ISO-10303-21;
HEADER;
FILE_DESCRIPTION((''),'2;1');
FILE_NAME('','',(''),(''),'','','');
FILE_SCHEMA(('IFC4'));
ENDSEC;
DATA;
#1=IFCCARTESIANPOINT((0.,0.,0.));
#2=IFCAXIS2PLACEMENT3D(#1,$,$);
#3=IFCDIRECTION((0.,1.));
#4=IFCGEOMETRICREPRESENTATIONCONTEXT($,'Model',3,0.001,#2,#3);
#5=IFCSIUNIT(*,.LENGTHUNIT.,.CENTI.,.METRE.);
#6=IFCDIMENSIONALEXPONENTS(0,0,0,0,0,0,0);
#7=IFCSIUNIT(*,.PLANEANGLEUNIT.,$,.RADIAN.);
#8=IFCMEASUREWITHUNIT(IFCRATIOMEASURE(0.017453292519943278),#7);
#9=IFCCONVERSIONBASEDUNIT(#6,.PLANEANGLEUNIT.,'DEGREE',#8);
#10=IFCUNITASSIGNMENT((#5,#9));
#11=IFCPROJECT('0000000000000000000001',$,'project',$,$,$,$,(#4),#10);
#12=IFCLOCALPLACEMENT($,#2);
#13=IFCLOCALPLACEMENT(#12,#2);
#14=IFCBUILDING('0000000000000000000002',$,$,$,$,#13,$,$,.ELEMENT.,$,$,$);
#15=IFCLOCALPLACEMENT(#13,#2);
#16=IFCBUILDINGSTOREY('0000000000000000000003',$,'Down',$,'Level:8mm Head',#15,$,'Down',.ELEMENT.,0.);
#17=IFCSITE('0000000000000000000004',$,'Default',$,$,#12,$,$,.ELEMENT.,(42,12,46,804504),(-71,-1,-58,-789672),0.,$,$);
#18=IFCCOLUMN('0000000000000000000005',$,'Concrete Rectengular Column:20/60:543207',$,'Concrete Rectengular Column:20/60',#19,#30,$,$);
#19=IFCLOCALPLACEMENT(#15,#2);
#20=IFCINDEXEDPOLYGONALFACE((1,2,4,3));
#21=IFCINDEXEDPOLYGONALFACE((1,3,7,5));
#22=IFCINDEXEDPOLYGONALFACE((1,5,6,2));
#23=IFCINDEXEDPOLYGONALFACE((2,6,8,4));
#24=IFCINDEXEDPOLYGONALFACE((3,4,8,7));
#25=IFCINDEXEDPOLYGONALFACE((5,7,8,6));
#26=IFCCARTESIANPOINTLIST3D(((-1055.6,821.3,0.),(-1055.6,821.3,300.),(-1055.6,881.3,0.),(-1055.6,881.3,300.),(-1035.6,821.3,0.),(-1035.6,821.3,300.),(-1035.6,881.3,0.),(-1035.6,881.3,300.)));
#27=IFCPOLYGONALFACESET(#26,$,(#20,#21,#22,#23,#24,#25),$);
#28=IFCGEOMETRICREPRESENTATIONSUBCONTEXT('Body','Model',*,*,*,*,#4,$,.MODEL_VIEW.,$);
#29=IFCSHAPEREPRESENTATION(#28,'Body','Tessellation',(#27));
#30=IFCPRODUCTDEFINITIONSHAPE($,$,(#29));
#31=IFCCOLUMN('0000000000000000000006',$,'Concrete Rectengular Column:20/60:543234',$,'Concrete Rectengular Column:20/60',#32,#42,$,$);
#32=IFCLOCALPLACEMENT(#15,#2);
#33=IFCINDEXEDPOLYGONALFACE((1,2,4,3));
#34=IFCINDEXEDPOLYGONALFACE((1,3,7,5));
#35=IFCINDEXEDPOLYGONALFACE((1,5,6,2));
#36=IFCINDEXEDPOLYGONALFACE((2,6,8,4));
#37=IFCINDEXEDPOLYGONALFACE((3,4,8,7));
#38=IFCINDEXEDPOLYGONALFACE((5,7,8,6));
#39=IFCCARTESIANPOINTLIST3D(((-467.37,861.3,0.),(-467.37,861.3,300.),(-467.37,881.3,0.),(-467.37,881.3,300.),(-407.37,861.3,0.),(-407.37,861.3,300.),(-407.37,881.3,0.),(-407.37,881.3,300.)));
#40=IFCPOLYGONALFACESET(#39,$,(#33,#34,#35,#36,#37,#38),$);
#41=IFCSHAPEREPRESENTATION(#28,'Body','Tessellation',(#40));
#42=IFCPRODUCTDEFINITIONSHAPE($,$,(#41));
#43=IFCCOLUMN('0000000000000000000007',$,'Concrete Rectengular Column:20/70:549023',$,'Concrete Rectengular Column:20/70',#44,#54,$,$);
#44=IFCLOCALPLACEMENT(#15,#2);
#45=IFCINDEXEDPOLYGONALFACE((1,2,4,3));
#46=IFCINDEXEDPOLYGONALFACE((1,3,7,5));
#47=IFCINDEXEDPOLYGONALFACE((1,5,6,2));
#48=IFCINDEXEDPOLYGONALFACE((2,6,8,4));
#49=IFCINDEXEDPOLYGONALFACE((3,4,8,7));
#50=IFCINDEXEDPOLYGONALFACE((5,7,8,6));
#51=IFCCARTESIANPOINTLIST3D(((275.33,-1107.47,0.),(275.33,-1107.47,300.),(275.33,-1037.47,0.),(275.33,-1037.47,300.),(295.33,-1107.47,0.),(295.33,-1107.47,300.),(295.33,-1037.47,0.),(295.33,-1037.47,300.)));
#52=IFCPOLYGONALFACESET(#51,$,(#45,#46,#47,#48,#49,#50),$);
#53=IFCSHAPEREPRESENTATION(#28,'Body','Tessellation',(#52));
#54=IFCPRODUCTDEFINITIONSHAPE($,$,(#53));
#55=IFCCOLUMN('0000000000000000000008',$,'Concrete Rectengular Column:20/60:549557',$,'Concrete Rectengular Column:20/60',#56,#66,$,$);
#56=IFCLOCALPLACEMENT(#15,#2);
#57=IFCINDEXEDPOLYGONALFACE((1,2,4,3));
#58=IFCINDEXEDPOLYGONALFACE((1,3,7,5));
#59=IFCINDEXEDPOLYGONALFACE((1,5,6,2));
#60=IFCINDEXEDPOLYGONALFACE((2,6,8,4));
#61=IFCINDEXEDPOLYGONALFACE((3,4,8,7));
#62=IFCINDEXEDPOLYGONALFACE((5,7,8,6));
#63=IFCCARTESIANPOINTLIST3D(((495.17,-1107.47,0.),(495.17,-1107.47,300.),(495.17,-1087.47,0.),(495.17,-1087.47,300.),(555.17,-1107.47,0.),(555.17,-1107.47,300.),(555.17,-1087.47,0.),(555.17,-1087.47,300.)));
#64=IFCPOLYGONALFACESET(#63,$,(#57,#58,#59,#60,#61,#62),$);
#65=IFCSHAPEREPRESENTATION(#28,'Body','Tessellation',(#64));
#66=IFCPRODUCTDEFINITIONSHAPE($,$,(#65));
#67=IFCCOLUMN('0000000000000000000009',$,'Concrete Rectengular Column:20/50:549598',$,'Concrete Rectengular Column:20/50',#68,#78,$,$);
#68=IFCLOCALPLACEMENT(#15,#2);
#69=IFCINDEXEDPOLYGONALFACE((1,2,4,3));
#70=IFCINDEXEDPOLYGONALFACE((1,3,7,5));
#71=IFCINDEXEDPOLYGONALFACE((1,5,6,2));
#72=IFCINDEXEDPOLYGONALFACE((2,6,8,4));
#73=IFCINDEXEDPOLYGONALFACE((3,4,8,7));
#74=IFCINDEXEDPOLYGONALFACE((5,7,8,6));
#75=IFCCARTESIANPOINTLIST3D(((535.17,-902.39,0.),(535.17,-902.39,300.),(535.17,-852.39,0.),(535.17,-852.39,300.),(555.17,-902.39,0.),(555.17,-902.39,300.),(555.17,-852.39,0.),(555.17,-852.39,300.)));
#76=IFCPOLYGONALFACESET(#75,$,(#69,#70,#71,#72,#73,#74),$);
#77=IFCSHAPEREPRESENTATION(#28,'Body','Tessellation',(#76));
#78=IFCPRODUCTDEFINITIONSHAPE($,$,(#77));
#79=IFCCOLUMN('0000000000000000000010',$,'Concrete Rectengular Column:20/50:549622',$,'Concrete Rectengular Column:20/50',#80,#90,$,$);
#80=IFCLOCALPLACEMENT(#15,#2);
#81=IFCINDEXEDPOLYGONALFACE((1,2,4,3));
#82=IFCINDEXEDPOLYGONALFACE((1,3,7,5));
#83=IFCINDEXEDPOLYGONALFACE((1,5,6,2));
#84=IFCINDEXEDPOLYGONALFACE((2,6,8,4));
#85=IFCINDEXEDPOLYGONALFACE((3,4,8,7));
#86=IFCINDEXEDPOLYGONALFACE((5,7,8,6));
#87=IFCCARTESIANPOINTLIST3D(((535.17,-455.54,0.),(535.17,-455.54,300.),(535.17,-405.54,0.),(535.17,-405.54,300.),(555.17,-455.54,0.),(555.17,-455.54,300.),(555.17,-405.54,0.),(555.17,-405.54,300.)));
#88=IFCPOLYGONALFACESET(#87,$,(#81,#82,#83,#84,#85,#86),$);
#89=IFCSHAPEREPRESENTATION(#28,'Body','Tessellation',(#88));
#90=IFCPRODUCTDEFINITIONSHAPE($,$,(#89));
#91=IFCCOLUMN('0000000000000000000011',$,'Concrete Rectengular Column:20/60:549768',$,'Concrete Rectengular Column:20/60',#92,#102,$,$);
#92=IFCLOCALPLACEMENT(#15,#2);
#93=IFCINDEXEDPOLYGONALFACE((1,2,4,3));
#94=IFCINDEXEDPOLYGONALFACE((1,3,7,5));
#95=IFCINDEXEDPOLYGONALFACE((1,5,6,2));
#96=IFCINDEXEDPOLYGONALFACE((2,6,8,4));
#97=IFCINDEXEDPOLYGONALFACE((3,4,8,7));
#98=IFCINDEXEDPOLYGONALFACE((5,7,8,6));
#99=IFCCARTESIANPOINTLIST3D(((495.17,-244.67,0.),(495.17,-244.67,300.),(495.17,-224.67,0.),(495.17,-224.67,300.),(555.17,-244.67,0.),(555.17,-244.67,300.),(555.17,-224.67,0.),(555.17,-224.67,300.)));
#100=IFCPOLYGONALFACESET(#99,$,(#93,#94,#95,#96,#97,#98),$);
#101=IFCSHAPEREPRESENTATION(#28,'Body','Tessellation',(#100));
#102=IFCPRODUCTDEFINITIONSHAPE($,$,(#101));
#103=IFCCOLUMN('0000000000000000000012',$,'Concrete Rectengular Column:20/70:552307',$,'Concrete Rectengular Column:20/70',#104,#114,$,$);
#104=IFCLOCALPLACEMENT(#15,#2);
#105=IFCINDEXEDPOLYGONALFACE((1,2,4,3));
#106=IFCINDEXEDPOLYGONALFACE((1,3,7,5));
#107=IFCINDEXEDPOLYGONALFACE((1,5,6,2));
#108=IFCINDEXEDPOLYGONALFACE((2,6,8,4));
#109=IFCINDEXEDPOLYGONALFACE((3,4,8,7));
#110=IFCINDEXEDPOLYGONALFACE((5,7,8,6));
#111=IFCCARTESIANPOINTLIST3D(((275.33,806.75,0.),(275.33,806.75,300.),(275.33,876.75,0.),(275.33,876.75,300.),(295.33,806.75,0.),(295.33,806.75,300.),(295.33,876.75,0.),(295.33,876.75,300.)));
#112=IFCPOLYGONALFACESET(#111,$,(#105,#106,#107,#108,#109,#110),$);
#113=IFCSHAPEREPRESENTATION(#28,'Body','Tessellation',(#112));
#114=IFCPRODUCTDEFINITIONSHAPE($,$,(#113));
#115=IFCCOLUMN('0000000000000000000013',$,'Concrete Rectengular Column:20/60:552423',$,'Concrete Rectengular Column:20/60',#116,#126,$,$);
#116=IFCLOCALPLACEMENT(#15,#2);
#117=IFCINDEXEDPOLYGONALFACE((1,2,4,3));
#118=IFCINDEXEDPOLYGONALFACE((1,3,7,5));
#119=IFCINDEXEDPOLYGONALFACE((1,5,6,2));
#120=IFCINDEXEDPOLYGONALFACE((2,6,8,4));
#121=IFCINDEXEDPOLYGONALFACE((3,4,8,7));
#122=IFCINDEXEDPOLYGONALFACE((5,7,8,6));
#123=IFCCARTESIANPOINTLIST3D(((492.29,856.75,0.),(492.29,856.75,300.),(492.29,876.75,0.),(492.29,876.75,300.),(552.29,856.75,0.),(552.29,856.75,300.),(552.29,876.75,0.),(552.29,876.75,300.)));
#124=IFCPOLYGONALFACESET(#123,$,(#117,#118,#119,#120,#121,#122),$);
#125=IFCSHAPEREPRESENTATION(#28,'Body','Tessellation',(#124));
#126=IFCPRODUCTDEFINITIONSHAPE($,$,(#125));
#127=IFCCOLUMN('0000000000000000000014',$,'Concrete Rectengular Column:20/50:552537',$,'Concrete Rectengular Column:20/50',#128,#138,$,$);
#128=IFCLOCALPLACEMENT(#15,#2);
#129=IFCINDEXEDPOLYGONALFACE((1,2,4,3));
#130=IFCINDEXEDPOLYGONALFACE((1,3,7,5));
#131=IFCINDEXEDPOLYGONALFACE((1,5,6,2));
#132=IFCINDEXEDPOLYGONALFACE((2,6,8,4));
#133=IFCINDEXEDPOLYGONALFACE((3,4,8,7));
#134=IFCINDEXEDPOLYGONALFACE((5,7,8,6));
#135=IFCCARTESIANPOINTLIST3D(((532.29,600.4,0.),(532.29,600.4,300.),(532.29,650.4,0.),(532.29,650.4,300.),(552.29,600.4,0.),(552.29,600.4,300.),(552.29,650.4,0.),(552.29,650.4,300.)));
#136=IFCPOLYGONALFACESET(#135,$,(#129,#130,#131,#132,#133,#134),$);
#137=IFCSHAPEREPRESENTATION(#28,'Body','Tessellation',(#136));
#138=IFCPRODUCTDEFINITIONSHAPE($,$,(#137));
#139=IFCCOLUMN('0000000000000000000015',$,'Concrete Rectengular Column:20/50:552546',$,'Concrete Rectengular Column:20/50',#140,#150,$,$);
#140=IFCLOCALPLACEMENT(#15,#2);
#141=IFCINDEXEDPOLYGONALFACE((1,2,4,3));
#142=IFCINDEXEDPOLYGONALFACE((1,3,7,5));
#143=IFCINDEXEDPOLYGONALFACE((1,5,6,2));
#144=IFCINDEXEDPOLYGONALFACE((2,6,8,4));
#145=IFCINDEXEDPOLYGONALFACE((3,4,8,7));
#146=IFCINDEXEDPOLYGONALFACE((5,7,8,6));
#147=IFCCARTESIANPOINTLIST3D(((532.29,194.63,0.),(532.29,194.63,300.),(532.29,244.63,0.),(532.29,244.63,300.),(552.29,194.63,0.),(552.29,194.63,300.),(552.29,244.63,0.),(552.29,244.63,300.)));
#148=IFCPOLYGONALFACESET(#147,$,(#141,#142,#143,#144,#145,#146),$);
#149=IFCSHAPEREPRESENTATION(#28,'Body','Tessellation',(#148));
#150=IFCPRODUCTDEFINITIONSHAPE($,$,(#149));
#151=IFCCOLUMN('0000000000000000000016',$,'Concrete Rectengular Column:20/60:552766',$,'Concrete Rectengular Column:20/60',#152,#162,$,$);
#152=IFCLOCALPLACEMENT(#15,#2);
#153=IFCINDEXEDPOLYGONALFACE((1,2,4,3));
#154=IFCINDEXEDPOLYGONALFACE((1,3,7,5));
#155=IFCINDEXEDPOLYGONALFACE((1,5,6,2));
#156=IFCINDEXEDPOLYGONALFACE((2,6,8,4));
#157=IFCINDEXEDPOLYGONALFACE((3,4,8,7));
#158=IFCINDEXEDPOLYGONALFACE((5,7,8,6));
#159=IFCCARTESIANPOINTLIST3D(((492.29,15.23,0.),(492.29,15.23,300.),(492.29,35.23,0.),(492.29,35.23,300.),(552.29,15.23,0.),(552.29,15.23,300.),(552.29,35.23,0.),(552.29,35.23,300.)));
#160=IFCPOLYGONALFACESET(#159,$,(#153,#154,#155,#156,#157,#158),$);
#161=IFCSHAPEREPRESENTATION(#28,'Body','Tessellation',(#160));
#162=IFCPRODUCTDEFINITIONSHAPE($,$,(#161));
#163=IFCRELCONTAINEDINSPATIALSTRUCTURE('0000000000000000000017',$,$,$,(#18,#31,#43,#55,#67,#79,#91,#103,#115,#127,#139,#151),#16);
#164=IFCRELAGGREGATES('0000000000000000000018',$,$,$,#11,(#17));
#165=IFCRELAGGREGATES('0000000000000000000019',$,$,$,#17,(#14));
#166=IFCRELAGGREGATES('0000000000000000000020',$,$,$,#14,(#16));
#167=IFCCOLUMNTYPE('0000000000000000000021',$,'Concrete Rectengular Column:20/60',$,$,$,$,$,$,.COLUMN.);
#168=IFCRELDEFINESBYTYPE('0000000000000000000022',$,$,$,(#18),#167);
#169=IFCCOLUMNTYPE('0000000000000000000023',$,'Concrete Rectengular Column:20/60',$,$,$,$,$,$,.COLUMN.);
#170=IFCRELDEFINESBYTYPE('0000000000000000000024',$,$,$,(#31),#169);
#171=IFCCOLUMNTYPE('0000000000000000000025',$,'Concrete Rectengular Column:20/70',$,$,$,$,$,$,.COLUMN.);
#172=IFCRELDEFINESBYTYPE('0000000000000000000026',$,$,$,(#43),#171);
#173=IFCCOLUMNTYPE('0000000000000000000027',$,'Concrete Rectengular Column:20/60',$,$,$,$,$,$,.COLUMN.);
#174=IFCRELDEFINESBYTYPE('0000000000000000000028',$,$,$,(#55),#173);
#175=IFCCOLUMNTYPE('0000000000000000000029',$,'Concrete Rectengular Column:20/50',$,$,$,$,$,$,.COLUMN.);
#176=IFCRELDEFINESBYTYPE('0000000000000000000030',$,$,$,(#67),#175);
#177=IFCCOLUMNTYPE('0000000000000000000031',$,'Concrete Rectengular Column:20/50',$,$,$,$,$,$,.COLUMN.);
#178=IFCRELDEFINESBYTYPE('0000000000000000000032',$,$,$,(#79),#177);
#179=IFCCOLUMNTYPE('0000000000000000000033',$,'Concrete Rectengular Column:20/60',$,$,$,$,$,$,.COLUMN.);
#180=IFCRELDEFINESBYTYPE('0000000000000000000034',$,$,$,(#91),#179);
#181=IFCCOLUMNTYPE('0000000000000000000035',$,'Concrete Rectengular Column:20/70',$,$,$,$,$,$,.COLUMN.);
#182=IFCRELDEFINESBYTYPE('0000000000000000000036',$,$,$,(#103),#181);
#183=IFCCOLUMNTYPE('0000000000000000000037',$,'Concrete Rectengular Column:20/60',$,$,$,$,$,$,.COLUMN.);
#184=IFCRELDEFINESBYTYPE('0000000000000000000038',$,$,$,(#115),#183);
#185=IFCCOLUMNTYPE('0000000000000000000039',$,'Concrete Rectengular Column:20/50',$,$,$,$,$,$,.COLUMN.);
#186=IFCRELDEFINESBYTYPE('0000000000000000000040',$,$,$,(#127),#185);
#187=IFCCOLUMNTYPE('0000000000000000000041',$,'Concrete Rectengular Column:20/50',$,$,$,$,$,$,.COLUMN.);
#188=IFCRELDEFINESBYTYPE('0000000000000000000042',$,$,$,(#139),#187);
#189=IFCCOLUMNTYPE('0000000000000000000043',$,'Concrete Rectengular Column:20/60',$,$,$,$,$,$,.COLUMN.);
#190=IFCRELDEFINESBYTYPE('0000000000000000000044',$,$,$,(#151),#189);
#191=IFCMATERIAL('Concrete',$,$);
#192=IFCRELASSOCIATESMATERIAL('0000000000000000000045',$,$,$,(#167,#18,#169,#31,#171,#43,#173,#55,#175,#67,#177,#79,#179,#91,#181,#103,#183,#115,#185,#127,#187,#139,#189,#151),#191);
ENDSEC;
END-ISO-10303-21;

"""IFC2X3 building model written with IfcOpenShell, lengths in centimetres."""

from ifc_helpers import new_model, entity, si_unit, converted_unit, direction, frame, frame_2d, origin, origin_2d_with_axis, place, context, subcontext, project, spatial, rectangle, extrude, source, transform, mapped, material, type_object, type_shapes, element, save


model = new_model("IFC2X3")

# Units and contexts
model_context = context("Model", 3, precision=0.001, world=origin(), true_north=direction((0.0, 1.0)))
body_context = subcontext(model_context, "Body", "Model", "MODEL_VIEW")
ifc_project = project(units=[si_unit("LENGTHUNIT", "METRE", prefix="CENTI"), converted_unit("PLANEANGLEUNIT", "DEGREE", entity("IfcRatioMeasure", 0.017453292519943278), si_unit("PLANEANGLEUNIT", "RADIAN"), dimensions=[0, 0, 0, 0, 0, 0, 0])], contexts=[model_context])

# Site, building, storey
site_placement = place(None, origin())
site = spatial("IfcSite", under=ifc_project, at=site_placement, Name="Default", CompositionType="ELEMENT", RefLatitude=(42, 12, 46, 804504), RefLongitude=(-71, -1, -58, -789672), RefElevation=0.0)
building_placement = place(site_placement, origin())
building = spatial("IfcBuilding", under=site, at=building_placement, CompositionType="ELEMENT")
storey_placement = place(building_placement, origin())
storey = spatial("IfcBuildingStorey", under=building, at=storey_placement, Name="Down", ObjectType="Level:8mm Head", LongName="Down", CompositionType="ELEMENT", Elevation=0.0)

# Columns
ifc_material = material(Name="Concrete")
column_type_1 = type_object("IfcColumnType", Name="Concrete Rectengular Column:20/60", PredefinedType="COLUMN", material=ifc_material)
shared_shape_1 = source(origin(), body_context, "Body", "SweptSolid", [
    extrude(rectangle(XDim=60.0, YDim=20.0, at=frame_2d((0.0, 0.0), x_axis=(1.0, 0.0))), frame((-1045.6, 851.3, 0.0), z_axis=(0.0, 0.0, 1.0), x_axis=(0.0, -1.0, 0.0)), (0.0, 0.0, 1.0), 300.0),
])
type_shapes(column_type_1, [shared_shape_1])
column_1_placement = place(storey_placement, origin())
element("IfcColumn", 1, at=column_1_placement, inside=storey, type_object=column_type_1, material=ifc_material, Name="Concrete Rectengular Column:20/60:543207", ObjectType="Concrete Rectengular Column:20/60", context=body_context, shape_type="MappedRepresentation", body=[
    mapped(shared_shape_1, transform((0.0, 0.0, 0.0), scale=1.0)),
])
column_type_2 = type_object("IfcColumnType", Name="Concrete Rectengular Column:20/60", PredefinedType="COLUMN", material=ifc_material)
shared_shape_2 = source(origin(), body_context, "Body", "SweptSolid", [
    extrude(rectangle(XDim=20.0, YDim=60.0, at=origin_2d_with_axis()), frame((-437.37, 871.3, 0.0), z_axis=(0.0, 0.0, 1.0), x_axis=(0.0, -1.0, 0.0)), (0.0, 0.0, 1.0), 300.0),
])
type_shapes(column_type_2, [shared_shape_2])
column_2_placement = place(storey_placement, origin())
element("IfcColumn", 2, at=column_2_placement, inside=storey, type_object=column_type_2, material=ifc_material, Name="Concrete Rectengular Column:20/60:543234", ObjectType="Concrete Rectengular Column:20/60", context=body_context, shape_type="MappedRepresentation", body=[
    mapped(shared_shape_2, transform((0.0, 0.0, 0.0), scale=1.0)),
])
column_type_3 = type_object("IfcColumnType", Name="Concrete Rectengular Column:20/70", PredefinedType="COLUMN", material=ifc_material)
shared_shape_3 = source(origin(), body_context, "Body", "SweptSolid", [
    extrude(rectangle(XDim=70.0, YDim=20.0, at=origin_2d_with_axis()), frame((285.33, -1072.47, 0.0), z_axis=(0.0, 0.0, 1.0), x_axis=(0.0, -1.0, 0.0)), (0.0, 0.0, 1.0), 300.0),
])
type_shapes(column_type_3, [shared_shape_3])
column_3_placement = place(storey_placement, origin())
element("IfcColumn", 3, at=column_3_placement, inside=storey, type_object=column_type_3, material=ifc_material, Name="Concrete Rectengular Column:20/70:549023", ObjectType="Concrete Rectengular Column:20/70", context=body_context, shape_type="MappedRepresentation", body=[
    mapped(shared_shape_3, transform((0.0, 0.0, 0.0), scale=1.0)),
])
column_type_4 = type_object("IfcColumnType", Name="Concrete Rectengular Column:20/60", PredefinedType="COLUMN", material=ifc_material)
shared_shape_4 = source(origin(), body_context, "Body", "SweptSolid", [
    extrude(rectangle(XDim=20.0, YDim=60.0, at=frame_2d((0.0, 0.0), x_axis=(1.0, 0.0))), frame((525.17, -1097.47, 0.0), z_axis=(0.0, 0.0, 1.0), x_axis=(0.0, -1.0, 0.0)), (0.0, 0.0, 1.0), 300.0),
])
type_shapes(column_type_4, [shared_shape_4])
column_4_placement = place(storey_placement, origin())
element("IfcColumn", 4, at=column_4_placement, inside=storey, type_object=column_type_4, material=ifc_material, Name="Concrete Rectengular Column:20/60:549557", ObjectType="Concrete Rectengular Column:20/60", context=body_context, shape_type="MappedRepresentation", body=[
    mapped(shared_shape_4, transform((0.0, 0.0, 0.0), scale=1.0)),
])
column_type_5 = type_object("IfcColumnType", Name="Concrete Rectengular Column:20/50", PredefinedType="COLUMN", material=ifc_material)
shared_shape_5 = source(origin(), body_context, "Body", "SweptSolid", [
    extrude(rectangle(XDim=50.0, YDim=20.0, at=origin_2d_with_axis()), frame((545.17, -877.39, 0.0), z_axis=(0.0, 0.0, 1.0), x_axis=(0.0, -1.0, 0.0)), (0.0, 0.0, 1.0), 300.0),
])
type_shapes(column_type_5, [shared_shape_5])
column_5_placement = place(storey_placement, origin())
element("IfcColumn", 5, at=column_5_placement, inside=storey, type_object=column_type_5, material=ifc_material, Name="Concrete Rectengular Column:20/50:549598", ObjectType="Concrete Rectengular Column:20/50", context=body_context, shape_type="MappedRepresentation", body=[
    mapped(shared_shape_5, transform((0.0, 0.0, 0.0), scale=1.0)),
])
column_type_6 = type_object("IfcColumnType", Name="Concrete Rectengular Column:20/50", PredefinedType="COLUMN", material=ifc_material)
shared_shape_6 = source(origin(), body_context, "Body", "SweptSolid", [
    extrude(rectangle(XDim=50.0, YDim=20.0, at=origin_2d_with_axis()), frame((545.17, -430.54, 0.0), z_axis=(0.0, 0.0, 1.0), x_axis=(0.0, -1.0, 0.0)), (0.0, 0.0, 1.0), 300.0),
])
type_shapes(column_type_6, [shared_shape_6])
column_6_placement = place(storey_placement, origin())
element("IfcColumn", 6, at=column_6_placement, inside=storey, type_object=column_type_6, material=ifc_material, Name="Concrete Rectengular Column:20/50:549622", ObjectType="Concrete Rectengular Column:20/50", context=body_context, shape_type="MappedRepresentation", body=[
    mapped(shared_shape_6, transform((0.0, 0.0, 0.0), scale=1.0)),
])
column_type_7 = type_object("IfcColumnType", Name="Concrete Rectengular Column:20/60", PredefinedType="COLUMN", material=ifc_material)
shared_shape_7 = source(origin(), body_context, "Body", "SweptSolid", [
    extrude(rectangle(XDim=20.0, YDim=60.0, at=frame_2d((0.0, 0.0), x_axis=(1.0, 0.0))), frame((525.17, -234.67, 0.0), z_axis=(0.0, 0.0, 1.0), x_axis=(0.0, -1.0, 0.0)), (0.0, 0.0, 1.0), 300.0),
])
type_shapes(column_type_7, [shared_shape_7])
column_7_placement = place(storey_placement, origin())
element("IfcColumn", 7, at=column_7_placement, inside=storey, type_object=column_type_7, material=ifc_material, Name="Concrete Rectengular Column:20/60:549768", ObjectType="Concrete Rectengular Column:20/60", context=body_context, shape_type="MappedRepresentation", body=[
    mapped(shared_shape_7, transform((0.0, 0.0, 0.0), scale=1.0)),
])
column_type_8 = type_object("IfcColumnType", Name="Concrete Rectengular Column:20/70", PredefinedType="COLUMN", material=ifc_material)
shared_shape_8 = source(origin(), body_context, "Body", "SweptSolid", [
    extrude(rectangle(XDim=70.0, YDim=20.0, at=frame_2d((0.0, 0.0), x_axis=(1.0, 0.0))), frame((285.33, 841.75, 0.0), z_axis=(0.0, 0.0, 1.0), x_axis=(0.0, -1.0, 0.0)), (0.0, 0.0, 1.0), 300.0),
])
type_shapes(column_type_8, [shared_shape_8])
column_8_placement = place(storey_placement, origin())
element("IfcColumn", 8, at=column_8_placement, inside=storey, type_object=column_type_8, material=ifc_material, Name="Concrete Rectengular Column:20/70:552307", ObjectType="Concrete Rectengular Column:20/70", context=body_context, shape_type="MappedRepresentation", body=[
    mapped(shared_shape_8, transform((0.0, 0.0, 0.0), scale=1.0)),
])
column_type_9 = type_object("IfcColumnType", Name="Concrete Rectengular Column:20/60", PredefinedType="COLUMN", material=ifc_material)
shared_shape_9 = source(origin(), body_context, "Body", "SweptSolid", [
    extrude(rectangle(XDim=20.0, YDim=60.0, at=frame_2d((0.0, 0.0), x_axis=(1.0, 0.0))), frame((522.29, 866.75, 0.0), z_axis=(0.0, 0.0, 1.0), x_axis=(0.0, -1.0, 0.0)), (0.0, 0.0, 1.0), 300.0),
])
type_shapes(column_type_9, [shared_shape_9])
column_9_placement = place(storey_placement, origin())
element("IfcColumn", 9, at=column_9_placement, inside=storey, type_object=column_type_9, material=ifc_material, Name="Concrete Rectengular Column:20/60:552423", ObjectType="Concrete Rectengular Column:20/60", context=body_context, shape_type="MappedRepresentation", body=[
    mapped(shared_shape_9, transform((0.0, 0.0, 0.0), scale=1.0)),
])
column_type_10 = type_object("IfcColumnType", Name="Concrete Rectengular Column:20/50", PredefinedType="COLUMN", material=ifc_material)
shared_shape_10 = source(origin(), body_context, "Body", "SweptSolid", [
    extrude(rectangle(XDim=50.0, YDim=20.0, at=origin_2d_with_axis()), frame((542.29, 625.4, 0.0), z_axis=(0.0, 0.0, 1.0), x_axis=(0.0, -1.0, 0.0)), (0.0, 0.0, 1.0), 300.0),
])
type_shapes(column_type_10, [shared_shape_10])
column_10_placement = place(storey_placement, origin())
element("IfcColumn", 10, at=column_10_placement, inside=storey, type_object=column_type_10, material=ifc_material, Name="Concrete Rectengular Column:20/50:552537", ObjectType="Concrete Rectengular Column:20/50", context=body_context, shape_type="MappedRepresentation", body=[
    mapped(shared_shape_10, transform((0.0, 0.0, 0.0), scale=1.0)),
])
column_type_11 = type_object("IfcColumnType", Name="Concrete Rectengular Column:20/50", PredefinedType="COLUMN", material=ifc_material)
shared_shape_11 = source(origin(), body_context, "Body", "SweptSolid", [
    extrude(rectangle(XDim=50.0, YDim=20.0, at=origin_2d_with_axis()), frame((542.29, 219.63, 0.0), z_axis=(0.0, 0.0, 1.0), x_axis=(0.0, -1.0, 0.0)), (0.0, 0.0, 1.0), 300.0),
])
type_shapes(column_type_11, [shared_shape_11])
column_11_placement = place(storey_placement, origin())
element("IfcColumn", 11, at=column_11_placement, inside=storey, type_object=column_type_11, material=ifc_material, Name="Concrete Rectengular Column:20/50:552546", ObjectType="Concrete Rectengular Column:20/50", context=body_context, shape_type="MappedRepresentation", body=[
    mapped(shared_shape_11, transform((0.0, 0.0, 0.0), scale=1.0)),
])
column_type_12 = type_object("IfcColumnType", Name="Concrete Rectengular Column:20/60", PredefinedType="COLUMN", material=ifc_material)
shared_shape_12 = source(origin(), body_context, "Body", "SweptSolid", [
    extrude(rectangle(XDim=20.0, YDim=60.0, at=frame_2d((0.0, 0.0), x_axis=(1.0, 0.0))), frame((522.29, 25.23, 0.0), z_axis=(0.0, 0.0, 1.0), x_axis=(0.0, -1.0, 0.0)), (0.0, 0.0, 1.0), 300.0),
])
type_shapes(column_type_12, [shared_shape_12])
column_12_placement = place(storey_placement, origin())
element("IfcColumn", 12, at=column_12_placement, inside=storey, type_object=column_type_12, material=ifc_material, Name="Concrete Rectengular Column:20/60:552766", ObjectType="Concrete Rectengular Column:20/60", context=body_context, shape_type="MappedRepresentation", body=[
    mapped(shared_shape_12, transform((0.0, 0.0, 0.0), scale=1.0)),
])

save(model, "model.ifc")
